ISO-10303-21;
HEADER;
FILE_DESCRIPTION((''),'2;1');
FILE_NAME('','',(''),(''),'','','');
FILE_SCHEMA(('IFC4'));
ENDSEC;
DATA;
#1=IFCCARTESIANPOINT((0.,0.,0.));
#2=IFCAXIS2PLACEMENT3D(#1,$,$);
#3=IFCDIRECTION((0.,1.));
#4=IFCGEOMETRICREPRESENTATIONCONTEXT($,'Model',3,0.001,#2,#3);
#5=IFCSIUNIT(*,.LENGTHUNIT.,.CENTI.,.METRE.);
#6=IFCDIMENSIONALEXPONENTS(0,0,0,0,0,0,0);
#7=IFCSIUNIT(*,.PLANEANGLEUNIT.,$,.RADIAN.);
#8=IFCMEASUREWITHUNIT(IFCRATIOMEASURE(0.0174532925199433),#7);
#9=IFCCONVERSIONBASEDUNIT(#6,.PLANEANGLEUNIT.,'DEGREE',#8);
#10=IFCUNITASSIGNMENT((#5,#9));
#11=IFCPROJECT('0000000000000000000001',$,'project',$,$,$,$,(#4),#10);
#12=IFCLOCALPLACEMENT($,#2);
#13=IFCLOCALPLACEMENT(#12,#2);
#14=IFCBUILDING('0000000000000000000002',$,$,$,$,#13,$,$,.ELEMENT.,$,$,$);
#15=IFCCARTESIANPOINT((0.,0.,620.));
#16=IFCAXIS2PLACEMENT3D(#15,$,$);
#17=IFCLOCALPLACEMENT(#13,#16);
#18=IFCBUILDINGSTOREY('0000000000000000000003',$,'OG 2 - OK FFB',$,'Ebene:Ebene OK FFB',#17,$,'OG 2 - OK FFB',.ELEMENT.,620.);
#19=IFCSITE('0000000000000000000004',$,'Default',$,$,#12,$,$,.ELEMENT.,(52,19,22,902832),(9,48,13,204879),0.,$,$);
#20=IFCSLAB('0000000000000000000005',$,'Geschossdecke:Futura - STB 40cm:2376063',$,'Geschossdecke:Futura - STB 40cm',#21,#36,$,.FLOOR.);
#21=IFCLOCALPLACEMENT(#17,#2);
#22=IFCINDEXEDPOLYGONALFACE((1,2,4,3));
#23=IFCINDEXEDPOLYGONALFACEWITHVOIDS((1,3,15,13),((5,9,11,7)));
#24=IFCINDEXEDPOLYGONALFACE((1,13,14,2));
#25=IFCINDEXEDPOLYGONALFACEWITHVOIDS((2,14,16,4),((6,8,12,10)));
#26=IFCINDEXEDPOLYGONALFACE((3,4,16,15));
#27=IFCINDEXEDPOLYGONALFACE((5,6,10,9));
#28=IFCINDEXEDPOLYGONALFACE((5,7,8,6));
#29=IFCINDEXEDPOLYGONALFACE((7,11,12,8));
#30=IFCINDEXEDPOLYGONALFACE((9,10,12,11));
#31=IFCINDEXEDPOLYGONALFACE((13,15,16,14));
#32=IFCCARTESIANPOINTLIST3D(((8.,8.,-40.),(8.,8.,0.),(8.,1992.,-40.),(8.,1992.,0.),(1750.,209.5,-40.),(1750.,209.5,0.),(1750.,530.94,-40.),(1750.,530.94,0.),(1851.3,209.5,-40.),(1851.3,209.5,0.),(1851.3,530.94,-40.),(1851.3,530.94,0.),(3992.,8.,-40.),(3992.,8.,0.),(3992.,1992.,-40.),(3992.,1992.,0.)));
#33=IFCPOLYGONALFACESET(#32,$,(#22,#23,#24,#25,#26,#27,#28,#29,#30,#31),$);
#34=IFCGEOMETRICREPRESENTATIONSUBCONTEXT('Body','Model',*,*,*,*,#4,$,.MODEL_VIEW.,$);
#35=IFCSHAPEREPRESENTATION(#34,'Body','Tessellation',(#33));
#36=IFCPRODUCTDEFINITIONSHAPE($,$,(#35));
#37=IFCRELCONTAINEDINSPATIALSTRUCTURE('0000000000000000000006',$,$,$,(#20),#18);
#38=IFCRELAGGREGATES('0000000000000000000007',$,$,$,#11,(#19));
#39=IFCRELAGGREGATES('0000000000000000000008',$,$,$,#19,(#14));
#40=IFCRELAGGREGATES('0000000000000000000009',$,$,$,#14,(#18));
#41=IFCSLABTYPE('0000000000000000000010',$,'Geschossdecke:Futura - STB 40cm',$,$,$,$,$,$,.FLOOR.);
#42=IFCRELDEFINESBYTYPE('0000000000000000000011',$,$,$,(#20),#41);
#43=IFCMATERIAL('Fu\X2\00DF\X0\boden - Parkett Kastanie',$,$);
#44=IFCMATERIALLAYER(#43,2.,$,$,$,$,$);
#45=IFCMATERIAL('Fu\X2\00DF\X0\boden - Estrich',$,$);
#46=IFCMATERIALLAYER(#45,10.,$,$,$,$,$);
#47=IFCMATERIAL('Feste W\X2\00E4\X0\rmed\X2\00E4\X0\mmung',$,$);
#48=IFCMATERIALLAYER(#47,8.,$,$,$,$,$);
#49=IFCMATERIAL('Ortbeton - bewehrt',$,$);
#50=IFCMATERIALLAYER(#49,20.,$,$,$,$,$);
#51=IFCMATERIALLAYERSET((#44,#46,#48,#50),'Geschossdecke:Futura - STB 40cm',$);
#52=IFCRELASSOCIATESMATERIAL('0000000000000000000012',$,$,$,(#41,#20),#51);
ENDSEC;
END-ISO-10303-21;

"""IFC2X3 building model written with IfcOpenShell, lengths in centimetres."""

from ifc_helpers import new_model, entity, si_unit, converted_unit, direction, frame, frame_2d, origin, place, context, subcontext, project, spatial, rectangle, extrude, material, layer, layer_set, layer_usage, type_object, element, save


model = new_model("IFC2X3")

# Units and contexts
model_context = context("Model", 3, precision=0.001, world=origin(), true_north=direction((0.0, 1.0)))
body_context = subcontext(model_context, "Body", "Model", "MODEL_VIEW")
ifc_project = project(units=[si_unit("LENGTHUNIT", "METRE", prefix="CENTI"), converted_unit("PLANEANGLEUNIT", "DEGREE", entity("IfcRatioMeasure", 0.0174532925199433), si_unit("PLANEANGLEUNIT", "RADIAN"), dimensions=[0, 0, 0, 0, 0, 0, 0])], contexts=[model_context])

# Site, building, storey
site_placement = place(None, frame((0.0, 0.0, 0.0)))
site = spatial("IfcSite", under=ifc_project, at=site_placement, Name="Default", CompositionType="ELEMENT", RefLatitude=(52, 19, 22, 902832), RefLongitude=(9, 48, 13, 204879), RefElevation=0.0)
building_placement = place(site_placement, origin())
building = spatial("IfcBuilding", under=site, at=building_placement, CompositionType="ELEMENT")
storey_placement = place(building_placement, frame((0.0, 0.0, 620.0)))
storey = spatial("IfcBuildingStorey", under=building, at=storey_placement, Name="OG 2 - OK FFB", ObjectType="Ebene:Ebene OK FFB", LongName="OG 2 - OK FFB", CompositionType="ELEMENT", Elevation=620.0)

# Slab, opening
ifc_material_1 = material(Name="Fußboden - Parkett Kastanie")
ifc_layer_1 = layer(ifc_material_1, 2.0)
ifc_material_2 = material(Name="Fußboden - Estrich")
ifc_layer_2 = layer(ifc_material_2, 10.0)
ifc_material_3 = material(Name="Feste Wärmedämmung")
ifc_layer_3 = layer(ifc_material_3, 8.0)
ifc_material_4 = material(Name="Ortbeton - bewehrt")
ifc_layer_4 = layer(ifc_material_4, 20.0)
ifc_layer_set = layer_set([ifc_layer_1, ifc_layer_2, ifc_layer_3, ifc_layer_4], Name="Geschossdecke:Futura - STB 40cm")
ifc_layer_usage = layer_usage(ifc_layer_set, "AXIS3", "POSITIVE", 0.0)
slab_type = type_object("IfcSlabType", Name="Geschossdecke:Futura - STB 40cm", PredefinedType="FLOOR", material=ifc_layer_set)
slab_placement = place(storey_placement, frame((8.0, 8.0, -40.0)))
slab = element("IfcSlab", 1, at=slab_placement, inside=storey, type_object=slab_type, material=ifc_layer_usage, Name="Geschossdecke:Futura - STB 40cm:2376063", ObjectType="Geschossdecke:Futura - STB 40cm", PredefinedType="FLOOR", context=body_context, shape_type="SweptSolid", body=[
    extrude(rectangle(XDim=1984.0, YDim=3984.0, at=frame_2d((0.0, 0.0), x_axis=(0.0, -1.0))), frame((1992.0, 992.0, 40.0), z_axis=(0.0, 0.0, -1.0), x_axis=(-1.0, 0.0, 0.0)), (0.0, 0.0, 1.0), 40.0),
])
opening_placement = place(storey_placement, frame((8.0, 8.0, -40.0)))
element("IfcOpeningElement", 2, at=opening_placement, cuts=slab, ObjectType="Opening", context=body_context, shape_type="SweptSolid", body=[
    extrude(rectangle(XDim=321.44, YDim=101.31, at=frame_2d((199.35, -629.78), x_axis=(0.0, 1.0))), frame((1992.0, 992.0, 40.0), z_axis=(0.0, 0.0, -1.0), x_axis=(-1.0, 0.0, 0.0)), (0.0, 0.0, 1.0), 40.0),
])

save(model, "model.ifc")
